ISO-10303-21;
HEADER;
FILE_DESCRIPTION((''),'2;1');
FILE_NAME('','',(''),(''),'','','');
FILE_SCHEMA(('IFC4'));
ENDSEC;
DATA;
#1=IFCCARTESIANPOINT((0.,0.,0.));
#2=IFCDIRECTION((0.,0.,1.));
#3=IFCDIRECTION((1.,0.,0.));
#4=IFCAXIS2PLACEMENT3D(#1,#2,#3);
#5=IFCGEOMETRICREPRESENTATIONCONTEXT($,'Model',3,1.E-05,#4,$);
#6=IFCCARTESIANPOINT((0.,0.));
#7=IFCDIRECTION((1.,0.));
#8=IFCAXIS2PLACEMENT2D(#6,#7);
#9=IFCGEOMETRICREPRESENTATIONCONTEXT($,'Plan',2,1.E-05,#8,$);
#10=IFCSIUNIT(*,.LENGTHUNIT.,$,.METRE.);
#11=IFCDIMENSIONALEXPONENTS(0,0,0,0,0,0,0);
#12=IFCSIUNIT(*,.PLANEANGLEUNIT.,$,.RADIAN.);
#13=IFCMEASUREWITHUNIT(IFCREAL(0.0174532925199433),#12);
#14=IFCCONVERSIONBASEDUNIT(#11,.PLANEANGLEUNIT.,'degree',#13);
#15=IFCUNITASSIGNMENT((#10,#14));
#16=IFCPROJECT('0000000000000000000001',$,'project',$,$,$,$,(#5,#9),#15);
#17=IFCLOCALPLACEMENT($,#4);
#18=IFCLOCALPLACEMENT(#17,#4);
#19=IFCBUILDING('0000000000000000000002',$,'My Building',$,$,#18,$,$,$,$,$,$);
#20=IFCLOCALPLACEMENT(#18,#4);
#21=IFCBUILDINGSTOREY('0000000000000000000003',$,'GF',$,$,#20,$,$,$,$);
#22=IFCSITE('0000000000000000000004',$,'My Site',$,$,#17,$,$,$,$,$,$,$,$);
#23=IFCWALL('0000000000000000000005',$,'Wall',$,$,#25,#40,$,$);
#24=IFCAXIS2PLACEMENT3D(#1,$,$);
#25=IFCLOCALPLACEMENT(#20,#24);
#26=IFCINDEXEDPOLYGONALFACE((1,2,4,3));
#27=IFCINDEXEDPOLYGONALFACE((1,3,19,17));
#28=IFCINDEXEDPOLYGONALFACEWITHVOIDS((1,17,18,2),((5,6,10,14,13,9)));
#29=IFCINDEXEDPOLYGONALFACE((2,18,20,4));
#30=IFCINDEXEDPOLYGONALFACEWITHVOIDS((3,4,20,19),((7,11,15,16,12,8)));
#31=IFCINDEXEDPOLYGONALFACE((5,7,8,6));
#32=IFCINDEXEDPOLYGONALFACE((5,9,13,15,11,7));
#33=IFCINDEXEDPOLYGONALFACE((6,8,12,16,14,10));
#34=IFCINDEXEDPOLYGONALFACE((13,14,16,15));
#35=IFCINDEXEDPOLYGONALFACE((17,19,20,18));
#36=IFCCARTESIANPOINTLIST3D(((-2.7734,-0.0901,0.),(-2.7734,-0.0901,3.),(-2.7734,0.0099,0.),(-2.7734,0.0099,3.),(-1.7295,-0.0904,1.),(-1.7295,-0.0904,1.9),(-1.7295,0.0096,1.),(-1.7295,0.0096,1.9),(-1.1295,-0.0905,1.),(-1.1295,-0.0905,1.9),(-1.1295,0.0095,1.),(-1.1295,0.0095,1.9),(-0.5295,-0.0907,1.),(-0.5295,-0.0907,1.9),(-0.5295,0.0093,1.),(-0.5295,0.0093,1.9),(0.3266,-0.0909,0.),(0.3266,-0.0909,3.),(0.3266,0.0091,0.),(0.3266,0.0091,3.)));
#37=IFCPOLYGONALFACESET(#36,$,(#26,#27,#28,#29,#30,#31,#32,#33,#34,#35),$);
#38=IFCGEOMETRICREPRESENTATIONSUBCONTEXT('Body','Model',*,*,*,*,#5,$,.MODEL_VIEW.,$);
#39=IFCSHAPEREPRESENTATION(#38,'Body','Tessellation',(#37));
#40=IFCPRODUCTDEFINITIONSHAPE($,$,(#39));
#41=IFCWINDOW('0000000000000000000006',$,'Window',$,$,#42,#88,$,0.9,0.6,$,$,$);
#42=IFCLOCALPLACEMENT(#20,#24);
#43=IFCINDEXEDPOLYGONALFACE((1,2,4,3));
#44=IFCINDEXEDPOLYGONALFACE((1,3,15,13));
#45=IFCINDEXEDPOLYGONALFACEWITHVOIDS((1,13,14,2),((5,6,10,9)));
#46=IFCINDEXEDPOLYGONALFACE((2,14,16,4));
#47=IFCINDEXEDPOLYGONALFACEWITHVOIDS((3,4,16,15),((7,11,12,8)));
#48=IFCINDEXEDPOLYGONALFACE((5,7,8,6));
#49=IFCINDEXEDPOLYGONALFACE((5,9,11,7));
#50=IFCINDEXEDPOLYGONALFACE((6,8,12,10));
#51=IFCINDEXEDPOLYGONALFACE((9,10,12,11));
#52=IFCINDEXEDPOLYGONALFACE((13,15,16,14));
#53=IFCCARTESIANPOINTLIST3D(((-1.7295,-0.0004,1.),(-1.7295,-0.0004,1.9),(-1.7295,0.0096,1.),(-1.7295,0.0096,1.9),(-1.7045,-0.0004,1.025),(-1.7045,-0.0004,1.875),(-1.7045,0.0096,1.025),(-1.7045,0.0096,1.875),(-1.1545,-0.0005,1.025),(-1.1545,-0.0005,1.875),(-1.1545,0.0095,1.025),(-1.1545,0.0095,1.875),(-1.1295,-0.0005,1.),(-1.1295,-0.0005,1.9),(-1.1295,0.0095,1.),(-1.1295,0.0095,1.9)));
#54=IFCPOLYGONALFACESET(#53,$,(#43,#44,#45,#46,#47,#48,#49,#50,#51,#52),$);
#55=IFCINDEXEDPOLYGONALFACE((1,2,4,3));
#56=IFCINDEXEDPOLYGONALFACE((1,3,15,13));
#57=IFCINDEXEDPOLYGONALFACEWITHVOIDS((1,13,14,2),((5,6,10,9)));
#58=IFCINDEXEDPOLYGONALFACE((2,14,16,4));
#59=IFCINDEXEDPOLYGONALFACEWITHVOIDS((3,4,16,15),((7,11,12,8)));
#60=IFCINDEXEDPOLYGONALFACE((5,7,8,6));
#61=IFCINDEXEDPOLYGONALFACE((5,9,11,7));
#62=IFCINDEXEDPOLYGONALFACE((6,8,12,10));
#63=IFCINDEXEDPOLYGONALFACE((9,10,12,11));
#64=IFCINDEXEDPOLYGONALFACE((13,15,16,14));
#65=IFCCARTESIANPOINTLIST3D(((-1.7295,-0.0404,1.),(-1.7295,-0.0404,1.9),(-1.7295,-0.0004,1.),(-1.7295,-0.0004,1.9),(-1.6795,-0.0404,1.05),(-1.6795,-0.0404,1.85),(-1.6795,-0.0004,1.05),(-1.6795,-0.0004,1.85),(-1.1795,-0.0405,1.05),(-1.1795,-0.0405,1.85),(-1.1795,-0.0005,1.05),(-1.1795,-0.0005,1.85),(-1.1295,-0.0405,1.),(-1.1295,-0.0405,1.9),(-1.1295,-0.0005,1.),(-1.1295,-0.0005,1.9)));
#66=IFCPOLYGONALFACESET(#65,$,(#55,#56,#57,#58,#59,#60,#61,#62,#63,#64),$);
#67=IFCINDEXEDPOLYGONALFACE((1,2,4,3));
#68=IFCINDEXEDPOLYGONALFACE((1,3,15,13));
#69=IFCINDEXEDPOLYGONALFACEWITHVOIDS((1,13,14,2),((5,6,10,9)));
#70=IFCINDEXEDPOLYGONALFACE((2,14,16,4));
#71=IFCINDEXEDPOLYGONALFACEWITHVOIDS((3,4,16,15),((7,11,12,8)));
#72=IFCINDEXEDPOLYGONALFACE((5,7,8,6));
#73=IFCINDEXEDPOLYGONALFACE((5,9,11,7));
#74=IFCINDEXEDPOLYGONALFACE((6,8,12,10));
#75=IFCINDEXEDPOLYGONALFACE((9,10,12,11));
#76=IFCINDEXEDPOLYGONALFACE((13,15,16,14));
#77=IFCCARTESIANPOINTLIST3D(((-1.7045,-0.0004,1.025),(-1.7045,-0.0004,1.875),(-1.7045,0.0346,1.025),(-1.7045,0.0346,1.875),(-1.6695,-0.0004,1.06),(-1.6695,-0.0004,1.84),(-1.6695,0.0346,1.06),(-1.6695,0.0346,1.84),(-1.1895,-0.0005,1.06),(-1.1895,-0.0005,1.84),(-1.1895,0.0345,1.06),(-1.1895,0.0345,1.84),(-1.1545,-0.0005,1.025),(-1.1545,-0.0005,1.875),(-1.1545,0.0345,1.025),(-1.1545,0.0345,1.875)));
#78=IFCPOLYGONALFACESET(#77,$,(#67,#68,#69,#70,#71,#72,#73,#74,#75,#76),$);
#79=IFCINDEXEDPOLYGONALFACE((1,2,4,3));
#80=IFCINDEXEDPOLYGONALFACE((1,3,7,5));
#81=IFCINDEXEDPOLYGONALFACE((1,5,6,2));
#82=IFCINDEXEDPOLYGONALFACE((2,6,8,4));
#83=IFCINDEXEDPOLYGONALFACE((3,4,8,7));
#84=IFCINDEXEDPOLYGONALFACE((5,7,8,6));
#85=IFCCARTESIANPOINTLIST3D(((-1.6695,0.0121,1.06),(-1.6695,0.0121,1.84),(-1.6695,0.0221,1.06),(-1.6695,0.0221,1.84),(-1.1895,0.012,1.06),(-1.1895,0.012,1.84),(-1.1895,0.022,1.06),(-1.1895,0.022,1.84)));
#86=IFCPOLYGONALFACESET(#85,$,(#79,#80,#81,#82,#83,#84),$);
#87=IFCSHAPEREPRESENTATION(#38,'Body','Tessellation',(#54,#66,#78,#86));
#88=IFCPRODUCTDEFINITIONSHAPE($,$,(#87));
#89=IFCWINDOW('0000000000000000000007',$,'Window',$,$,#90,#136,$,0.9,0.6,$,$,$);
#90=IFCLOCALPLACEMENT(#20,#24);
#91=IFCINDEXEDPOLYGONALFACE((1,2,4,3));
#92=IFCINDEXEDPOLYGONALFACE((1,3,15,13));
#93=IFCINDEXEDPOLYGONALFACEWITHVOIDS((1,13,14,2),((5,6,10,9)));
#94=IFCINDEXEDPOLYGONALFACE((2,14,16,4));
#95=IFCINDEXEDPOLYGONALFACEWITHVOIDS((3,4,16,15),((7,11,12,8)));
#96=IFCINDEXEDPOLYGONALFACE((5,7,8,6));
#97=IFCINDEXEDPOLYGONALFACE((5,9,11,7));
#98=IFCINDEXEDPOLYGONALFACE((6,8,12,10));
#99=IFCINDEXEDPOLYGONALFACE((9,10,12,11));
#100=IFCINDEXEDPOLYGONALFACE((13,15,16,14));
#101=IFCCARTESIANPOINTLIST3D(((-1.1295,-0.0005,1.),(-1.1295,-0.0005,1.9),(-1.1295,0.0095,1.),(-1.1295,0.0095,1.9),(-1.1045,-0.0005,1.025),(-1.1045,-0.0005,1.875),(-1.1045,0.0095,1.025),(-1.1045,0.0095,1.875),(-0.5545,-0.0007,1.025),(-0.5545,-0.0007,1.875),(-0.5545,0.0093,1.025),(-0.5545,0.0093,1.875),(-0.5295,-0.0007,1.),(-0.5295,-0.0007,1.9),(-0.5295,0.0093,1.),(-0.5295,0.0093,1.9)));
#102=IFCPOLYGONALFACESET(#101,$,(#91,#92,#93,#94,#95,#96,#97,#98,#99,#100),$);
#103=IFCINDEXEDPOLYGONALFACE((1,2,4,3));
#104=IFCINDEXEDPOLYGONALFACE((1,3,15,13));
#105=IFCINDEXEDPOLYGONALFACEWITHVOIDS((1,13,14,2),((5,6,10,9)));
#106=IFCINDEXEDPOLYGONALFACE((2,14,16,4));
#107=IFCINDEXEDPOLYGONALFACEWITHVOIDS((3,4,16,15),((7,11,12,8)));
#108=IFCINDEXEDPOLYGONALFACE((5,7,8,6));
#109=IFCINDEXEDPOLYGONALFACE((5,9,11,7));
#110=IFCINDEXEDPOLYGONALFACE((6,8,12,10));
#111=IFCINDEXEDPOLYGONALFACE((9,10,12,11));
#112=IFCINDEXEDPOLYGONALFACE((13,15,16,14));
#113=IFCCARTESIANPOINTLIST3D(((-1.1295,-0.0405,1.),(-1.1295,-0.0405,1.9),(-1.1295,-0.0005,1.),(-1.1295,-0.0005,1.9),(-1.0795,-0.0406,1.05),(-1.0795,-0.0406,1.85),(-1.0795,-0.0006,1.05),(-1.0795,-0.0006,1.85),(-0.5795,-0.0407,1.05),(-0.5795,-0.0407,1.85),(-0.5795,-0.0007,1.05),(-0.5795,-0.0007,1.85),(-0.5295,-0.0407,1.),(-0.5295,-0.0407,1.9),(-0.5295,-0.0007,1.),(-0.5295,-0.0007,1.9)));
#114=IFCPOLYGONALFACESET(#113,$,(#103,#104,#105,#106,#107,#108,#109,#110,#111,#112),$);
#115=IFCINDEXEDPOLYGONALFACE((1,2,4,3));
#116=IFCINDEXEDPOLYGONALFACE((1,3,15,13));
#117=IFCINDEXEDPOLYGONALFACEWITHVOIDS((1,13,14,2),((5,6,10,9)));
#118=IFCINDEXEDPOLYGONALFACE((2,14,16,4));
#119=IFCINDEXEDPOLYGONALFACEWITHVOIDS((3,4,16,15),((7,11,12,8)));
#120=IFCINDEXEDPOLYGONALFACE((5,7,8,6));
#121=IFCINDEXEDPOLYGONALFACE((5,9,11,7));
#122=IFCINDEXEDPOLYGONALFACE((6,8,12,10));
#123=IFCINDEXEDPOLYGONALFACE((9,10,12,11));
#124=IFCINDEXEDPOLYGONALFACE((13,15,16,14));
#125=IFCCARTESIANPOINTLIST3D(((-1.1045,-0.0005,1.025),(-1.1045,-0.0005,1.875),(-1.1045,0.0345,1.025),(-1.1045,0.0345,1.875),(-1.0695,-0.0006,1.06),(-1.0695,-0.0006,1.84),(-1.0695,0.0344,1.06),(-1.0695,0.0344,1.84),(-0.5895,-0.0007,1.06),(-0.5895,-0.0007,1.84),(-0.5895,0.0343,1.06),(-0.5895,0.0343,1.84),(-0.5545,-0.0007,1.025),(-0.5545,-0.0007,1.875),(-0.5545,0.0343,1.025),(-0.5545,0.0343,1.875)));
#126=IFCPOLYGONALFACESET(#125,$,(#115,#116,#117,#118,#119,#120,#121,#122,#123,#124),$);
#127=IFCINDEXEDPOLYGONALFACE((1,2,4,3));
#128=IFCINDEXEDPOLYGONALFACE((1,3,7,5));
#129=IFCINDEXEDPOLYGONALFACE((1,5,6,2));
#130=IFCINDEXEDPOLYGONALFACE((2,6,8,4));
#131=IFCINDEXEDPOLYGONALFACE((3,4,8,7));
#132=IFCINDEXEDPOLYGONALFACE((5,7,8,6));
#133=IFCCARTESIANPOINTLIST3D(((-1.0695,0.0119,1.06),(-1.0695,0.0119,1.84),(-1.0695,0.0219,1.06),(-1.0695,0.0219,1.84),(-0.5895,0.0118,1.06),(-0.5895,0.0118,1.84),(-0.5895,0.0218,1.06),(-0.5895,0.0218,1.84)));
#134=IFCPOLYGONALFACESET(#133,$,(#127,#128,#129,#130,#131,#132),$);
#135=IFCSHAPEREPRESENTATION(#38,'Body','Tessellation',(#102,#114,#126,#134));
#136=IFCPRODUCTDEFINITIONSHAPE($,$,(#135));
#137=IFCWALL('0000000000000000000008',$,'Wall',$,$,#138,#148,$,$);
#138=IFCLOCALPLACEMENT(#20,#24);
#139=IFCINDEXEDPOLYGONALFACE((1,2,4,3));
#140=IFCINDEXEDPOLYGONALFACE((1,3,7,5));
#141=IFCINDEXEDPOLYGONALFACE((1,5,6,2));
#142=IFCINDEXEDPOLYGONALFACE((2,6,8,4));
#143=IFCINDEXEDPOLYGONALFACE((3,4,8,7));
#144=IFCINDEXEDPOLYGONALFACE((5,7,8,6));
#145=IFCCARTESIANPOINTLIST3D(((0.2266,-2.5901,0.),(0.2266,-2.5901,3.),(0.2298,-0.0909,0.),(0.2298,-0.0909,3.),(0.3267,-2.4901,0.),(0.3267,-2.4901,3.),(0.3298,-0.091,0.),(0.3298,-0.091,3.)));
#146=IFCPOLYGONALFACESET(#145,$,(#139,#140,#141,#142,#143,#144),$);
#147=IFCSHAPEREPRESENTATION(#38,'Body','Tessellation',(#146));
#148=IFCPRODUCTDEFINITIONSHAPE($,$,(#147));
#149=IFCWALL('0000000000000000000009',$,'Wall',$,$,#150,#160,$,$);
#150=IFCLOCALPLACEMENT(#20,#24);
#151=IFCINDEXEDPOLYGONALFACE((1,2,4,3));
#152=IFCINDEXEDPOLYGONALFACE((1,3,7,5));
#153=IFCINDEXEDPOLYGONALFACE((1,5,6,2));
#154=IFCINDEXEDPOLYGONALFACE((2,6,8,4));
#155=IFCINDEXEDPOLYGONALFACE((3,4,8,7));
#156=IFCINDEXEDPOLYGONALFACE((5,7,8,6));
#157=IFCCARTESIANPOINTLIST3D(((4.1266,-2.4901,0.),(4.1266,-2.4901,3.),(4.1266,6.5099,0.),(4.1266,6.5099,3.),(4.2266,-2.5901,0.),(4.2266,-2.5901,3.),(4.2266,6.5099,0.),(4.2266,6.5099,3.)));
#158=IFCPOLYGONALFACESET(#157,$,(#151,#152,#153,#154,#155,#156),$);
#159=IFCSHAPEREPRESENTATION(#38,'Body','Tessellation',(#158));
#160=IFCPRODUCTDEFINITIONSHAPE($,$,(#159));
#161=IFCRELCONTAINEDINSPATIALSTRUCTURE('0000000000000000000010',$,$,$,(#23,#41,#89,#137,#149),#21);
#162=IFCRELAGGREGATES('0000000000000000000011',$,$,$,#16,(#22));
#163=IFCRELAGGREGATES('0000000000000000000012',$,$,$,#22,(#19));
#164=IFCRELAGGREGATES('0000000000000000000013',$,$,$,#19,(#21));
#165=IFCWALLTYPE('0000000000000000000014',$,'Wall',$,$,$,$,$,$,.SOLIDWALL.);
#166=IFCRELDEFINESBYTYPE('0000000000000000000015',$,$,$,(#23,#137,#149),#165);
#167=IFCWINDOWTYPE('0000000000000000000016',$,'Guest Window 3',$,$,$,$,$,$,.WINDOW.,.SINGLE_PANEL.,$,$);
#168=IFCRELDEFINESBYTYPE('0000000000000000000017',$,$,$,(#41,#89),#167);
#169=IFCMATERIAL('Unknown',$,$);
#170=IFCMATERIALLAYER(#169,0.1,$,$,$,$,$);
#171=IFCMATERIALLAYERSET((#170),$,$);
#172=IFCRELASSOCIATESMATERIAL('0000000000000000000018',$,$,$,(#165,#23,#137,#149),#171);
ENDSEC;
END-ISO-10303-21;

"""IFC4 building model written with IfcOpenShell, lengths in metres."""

from ifc_helpers import new_model, entity, si_unit, converted_unit, frame, origin_with_axes, origin_2d_with_axis, place, context, subcontext, project, spatial, line, indexed_curve, outline, extrude, shape, source, transform, mapped, material, layer, layer_set, layer_usage, type_object, type_shapes, element, fill, save


model = new_model("IFC4")

# Units and contexts
model_context = context("Model", 3, precision=1e-05, world=origin_with_axes())
plan_context = context("Plan", 2, precision=1e-05, world=origin_2d_with_axis())
body_context_1 = subcontext(model_context, "Body", "Model", "MODEL_VIEW")
body_context_2 = subcontext(plan_context, "Body", "Plan", "PLAN_VIEW")
ifc_project = project(units=[si_unit("LENGTHUNIT", "METRE"), converted_unit("PLANEANGLEUNIT", "degree", entity("IfcReal", 0.0174532925199433), si_unit("PLANEANGLEUNIT", "RADIAN"), dimensions=[0, 0, 0, 0, 0, 0, 0])], contexts=[model_context, plan_context])

# Site, building, storey
site_placement = place(None, origin_with_axes())
site = spatial("IfcSite", under=ifc_project, at=site_placement, Name="My Site")
building_placement = place(site_placement, origin_with_axes())
building = spatial("IfcBuilding", under=site, at=building_placement, Name="My Building")
storey_placement = place(building_placement, origin_with_axes())
storey = spatial("IfcBuildingStorey", under=building, at=storey_placement, Name="GF")

# Shared definitions
ifc_material = material(Name="Unknown")

# Shared definitions
ifc_layer_1 = layer(ifc_material, 0.1)
ifc_layer_set_1 = layer_set([ifc_layer_1])
wall_type = type_object("IfcWallType", Name="Wall", PredefinedType="SOLIDWALL", material=ifc_layer_set_1)

# Wall, openings, windows
ifc_layer_usage_1 = layer_usage(ifc_layer_set_1, "AXIS2", "POSITIVE", 0.0)
wall_1_placement = place(storey_placement, frame((-2.7734, -0.0901, 0.0), z_axis=(0.0, 0.0, 1.0), x_axis=(1.0, -0.000264, 0.0)))
wall_1 = element("IfcWall", 1, at=wall_1_placement, inside=storey, type_object=wall_type, material=ifc_layer_usage_1, Name="Wall", context=body_context_1, shape_type="SweptSolid", body=[
    extrude(outline(indexed_curve([(0.0, 0.0), (0.0, 0.1), (3.1, 0.1), (3.1, 0.0)], segments=[line(1, 2, 3, 4, 1)])), origin_with_axes(), (0.0, 0.0, 1.0), 3.0),
])
shared_shape_1 = source(origin_with_axes(), body_context_1, "Body", "SweptSolid", [
    extrude(outline(indexed_curve([(0.0, 0.0), (0.6, 0.0), (0.6, 0.9), (0.0, 0.9)], segments=[line(1, 2, 3, 4, 1)])), frame((0.0, -0.6, 0.0), z_axis=(0.0, -1.0, 0.0), x_axis=(1.0, 0.0, 0.0)), (0.0, 0.0, -1.0), 1.2),
])
opening_1_placement = place(wall_1_placement, frame((1.0439, 0.0, 1.0), z_axis=(0.0, 0.0, 1.0), x_axis=(1.0, 0.0, 0.0)))
opening_1 = element("IfcOpeningElement", 2, at=opening_1_placement, cuts=wall_1, PredefinedType="OPENING", context=body_context_1, shape_type="MappedRepresentation", body=[
    mapped(shared_shape_1, transform((0.0, 0.0, 0.0), x_axis=(1.0, 0.0, 0.0), y_axis=(0.0, 1.0, 0.0), z_axis=(0.0, 0.0, 1.0), scale=1.0)),
])
opening_2_placement = place(wall_1_placement, frame((1.6439, 0.0, 1.0), z_axis=(0.0, 0.0, 1.0), x_axis=(1.0, 0.0, 0.0)))
opening_2 = element("IfcOpeningElement", 3, at=opening_2_placement, cuts=wall_1, PredefinedType="OPENING", context=body_context_1, shape_type="MappedRepresentation", body=[
    mapped(shared_shape_1, transform((0.0, 0.0, 0.0), x_axis=(1.0, 0.0, 0.0), y_axis=(0.0, 1.0, 0.0), z_axis=(0.0, 0.0, 1.0), scale=1.0)),
])
window_type_1 = type_object("IfcWindowType", Name="Guest Window 3", PartitioningType="SINGLE_PANEL", PredefinedType="WINDOW")
shared_shape_2 = source(origin_with_axes(), body_context_1, "Body", "SweptSolid", [
    extrude(outline(indexed_curve([(0.0, 0.0), (0.6, 0.0), (0.6, 0.9), (0.0, 0.9)], segments=[line(1, 2, 3, 4, 1)]), holes=[indexed_curve([(0.025, 0.025), (0.575, 0.025), (0.575, 0.875), (0.025, 0.875)], segments=[line(1, 2, 3, 4, 1)])]), frame((0.0, 0.09, 0.0), z_axis=(0.0, -1.0, 0.0), x_axis=(1.0, 0.0, 0.0)), (0.0, 0.0, -1.0), 0.01),
    extrude(outline(indexed_curve([(0.0, 0.0), (0.6, 0.0), (0.6, 0.9), (0.0, 0.9)], segments=[line(1, 2, 3, 4, 1)]), holes=[indexed_curve([(0.05, 0.05), (0.55, 0.05), (0.55, 0.85), (0.05, 0.85)], segments=[line(1, 2, 3, 4, 1)])]), frame((0.0, 0.05, 0.0), z_axis=(0.0, -1.0, 0.0), x_axis=(1.0, 0.0, 0.0)), (0.0, 0.0, -1.0), 0.04),
    extrude(outline(indexed_curve([(0.0, 0.0), (0.55, 0.0), (0.55, 0.85), (0.0, 0.85)], segments=[line(1, 2, 3, 4, 1)]), holes=[indexed_curve([(0.035, 0.035), (0.515, 0.035), (0.515, 0.815), (0.035, 0.815)], segments=[line(1, 2, 3, 4, 1)])]), frame((0.025, 0.09, 0.025), z_axis=(0.0, -1.0, 0.0), x_axis=(1.0, 0.0, 0.0)), (0.0, 0.0, -1.0), 0.035),
    extrude(outline(indexed_curve([(0.035, 0.035), (0.515, 0.035), (0.515, 0.815), (0.035, 0.815)], segments=[line(1, 2, 3, 4, 1)])), frame((0.025, 0.1025, 0.025), z_axis=(0.0, -1.0, 0.0), x_axis=(1.0, 0.0, 0.0)), (0.0, 0.0, -1.0), 0.01),
])
shared_shape_3 = source(origin_with_axes(), body_context_2, "Body", "Curve2D", [
    entity("IfcIndexedPolyCurve", entity("IfcCartesianPointList2D", [[0.05, 0.05], [0.55, 0.05]])),
    entity("IfcIndexedPolyCurve", entity("IfcCartesianPointList2D", [[0.0, 0.1], [0.025, 0.1], [0.025, 0.09], [0.05, 0.09], [0.05, 0.05], [0.0, 0.05]]), [entity("IfcLineIndex", [1, 2, 3, 4, 5, 6, 1])]),
    entity("IfcIndexedPolyCurve", entity("IfcCartesianPointList2D", [[0.6, 0.1], [0.575, 0.1], [0.575, 0.09], [0.55, 0.09], [0.55, 0.05], [0.6, 0.05]]), [entity("IfcLineIndex", [1, 2, 3, 4, 5, 6, 1])]),
    entity("IfcIndexedPolyCurve", entity("IfcCartesianPointList2D", [[0.025, 0.09], [0.06, 0.09], [0.06, 0.125], [0.025, 0.125]]), [entity("IfcLineIndex", [1, 2, 3, 4, 1])]),
    entity("IfcIndexedPolyCurve", entity("IfcCartesianPointList2D", [[0.575, 0.09], [0.54, 0.09], [0.54, 0.125], [0.575, 0.125]]), [entity("IfcLineIndex", [1, 2, 3, 4, 1])]),
    entity("IfcIndexedPolyCurve", entity("IfcCartesianPointList2D", [[0.06, 0.09], [0.54, 0.09]])),
    entity("IfcIndexedPolyCurve", entity("IfcCartesianPointList2D", [[0.06, 0.125], [0.54, 0.125]])),
    entity("IfcIndexedPolyCurve", entity("IfcCartesianPointList2D", [[0.06, 0.1075], [0.54, 0.1075]])),
])
type_shapes(window_type_1, [shared_shape_2, shared_shape_3])
window_1_placement = place(opening_1_placement, frame((0.0, 0.0, 0.0), z_axis=(0.0, 0.0, 1.0), x_axis=(1.0, 0.0, 0.0)))
window_1 = element("IfcWindow", 4, at=window_1_placement, inside=storey, type_object=window_type_1, Name="Window", OverallHeight=0.9, OverallWidth=0.6, shapes=[
    shape(body_context_1, "Body", "MappedRepresentation", [mapped(shared_shape_2, transform((0.0, 0.0, 0.0), x_axis=(1.0, 0.0, 0.0), y_axis=(0.0, 1.0, 0.0), z_axis=(0.0, 0.0, 1.0), scale=1.0))]),
    shape(body_context_2, "Body", "MappedRepresentation", [mapped(shared_shape_3, transform((0.0, 0.0, 0.0), x_axis=(1.0, 0.0, 0.0), y_axis=(0.0, 1.0, 0.0), z_axis=(0.0, 0.0, 1.0), scale=1.0))]),
])
fill(opening_1, window_1)
window_2_placement = place(opening_2_placement, frame((0.0, 0.0, 0.0), z_axis=(0.0, 0.0, 1.0), x_axis=(1.0, 0.0, 0.0)))
window_2 = element("IfcWindow", 5, at=window_2_placement, inside=storey, type_object=window_type_1, Name="Window", OverallHeight=0.9, OverallWidth=0.6, shapes=[
    shape(body_context_1, "Body", "MappedRepresentation", [mapped(shared_shape_2, transform((0.0, 0.0, 0.0), x_axis=(1.0, 0.0, 0.0), y_axis=(0.0, 1.0, 0.0), z_axis=(0.0, 0.0, 1.0), scale=1.0))]),
    shape(body_context_2, "Body", "MappedRepresentation", [mapped(shared_shape_3, transform((0.0, 0.0, 0.0), x_axis=(1.0, 0.0, 0.0), y_axis=(0.0, 1.0, 0.0), z_axis=(0.0, 0.0, 1.0), scale=1.0))]),
])
fill(opening_2, window_2)

# Wall
ifc_layer_usage_2 = layer_usage(ifc_layer_set_1, "AXIS2", "POSITIVE", 0.0)
wall_2_placement = place(storey_placement, frame((0.2298, -0.0909, 0.0), z_axis=(0.0, 0.0, 1.0), x_axis=(-0.001286, -0.999999, 0.0)))
element("IfcWall", 6, at=wall_2_placement, inside=storey, type_object=wall_type, material=ifc_layer_usage_2, Name="Wall", context=body_context_1, shape_type="SweptSolid", body=[
    extrude(outline(indexed_curve([(0.0, 0.0), (0.0, 0.1), (2.3991, 0.1), (2.4992, 0.0)], segments=[line(1, 2, 3, 4, 1)])), origin_with_axes(), (0.0, 0.0, 1.0), 3.0),
])

# Wall
ifc_layer_usage_3 = layer_usage(ifc_layer_set_1, "AXIS2", "POSITIVE", 0.0)
wall_3_placement = place(storey_placement, frame((4.2266, -2.5901, 0.0), z_axis=(0.0, 0.0, 1.0), x_axis=(0.0, 1.0, 0.0)))
element("IfcWall", 7, at=wall_3_placement, inside=storey, type_object=wall_type, material=ifc_layer_usage_3, Name="Wall", context=body_context_1, shape_type="SweptSolid", body=[
    extrude(outline(indexed_curve([(0.0, 0.0), (0.1, 0.1), (9.1, 0.1), (9.1, 0.0)], segments=[line(1, 2, 3, 4, 1)])), origin_with_axes(), (0.0, 0.0, 1.0), 3.0),
])

save(model, "model.ifc")
